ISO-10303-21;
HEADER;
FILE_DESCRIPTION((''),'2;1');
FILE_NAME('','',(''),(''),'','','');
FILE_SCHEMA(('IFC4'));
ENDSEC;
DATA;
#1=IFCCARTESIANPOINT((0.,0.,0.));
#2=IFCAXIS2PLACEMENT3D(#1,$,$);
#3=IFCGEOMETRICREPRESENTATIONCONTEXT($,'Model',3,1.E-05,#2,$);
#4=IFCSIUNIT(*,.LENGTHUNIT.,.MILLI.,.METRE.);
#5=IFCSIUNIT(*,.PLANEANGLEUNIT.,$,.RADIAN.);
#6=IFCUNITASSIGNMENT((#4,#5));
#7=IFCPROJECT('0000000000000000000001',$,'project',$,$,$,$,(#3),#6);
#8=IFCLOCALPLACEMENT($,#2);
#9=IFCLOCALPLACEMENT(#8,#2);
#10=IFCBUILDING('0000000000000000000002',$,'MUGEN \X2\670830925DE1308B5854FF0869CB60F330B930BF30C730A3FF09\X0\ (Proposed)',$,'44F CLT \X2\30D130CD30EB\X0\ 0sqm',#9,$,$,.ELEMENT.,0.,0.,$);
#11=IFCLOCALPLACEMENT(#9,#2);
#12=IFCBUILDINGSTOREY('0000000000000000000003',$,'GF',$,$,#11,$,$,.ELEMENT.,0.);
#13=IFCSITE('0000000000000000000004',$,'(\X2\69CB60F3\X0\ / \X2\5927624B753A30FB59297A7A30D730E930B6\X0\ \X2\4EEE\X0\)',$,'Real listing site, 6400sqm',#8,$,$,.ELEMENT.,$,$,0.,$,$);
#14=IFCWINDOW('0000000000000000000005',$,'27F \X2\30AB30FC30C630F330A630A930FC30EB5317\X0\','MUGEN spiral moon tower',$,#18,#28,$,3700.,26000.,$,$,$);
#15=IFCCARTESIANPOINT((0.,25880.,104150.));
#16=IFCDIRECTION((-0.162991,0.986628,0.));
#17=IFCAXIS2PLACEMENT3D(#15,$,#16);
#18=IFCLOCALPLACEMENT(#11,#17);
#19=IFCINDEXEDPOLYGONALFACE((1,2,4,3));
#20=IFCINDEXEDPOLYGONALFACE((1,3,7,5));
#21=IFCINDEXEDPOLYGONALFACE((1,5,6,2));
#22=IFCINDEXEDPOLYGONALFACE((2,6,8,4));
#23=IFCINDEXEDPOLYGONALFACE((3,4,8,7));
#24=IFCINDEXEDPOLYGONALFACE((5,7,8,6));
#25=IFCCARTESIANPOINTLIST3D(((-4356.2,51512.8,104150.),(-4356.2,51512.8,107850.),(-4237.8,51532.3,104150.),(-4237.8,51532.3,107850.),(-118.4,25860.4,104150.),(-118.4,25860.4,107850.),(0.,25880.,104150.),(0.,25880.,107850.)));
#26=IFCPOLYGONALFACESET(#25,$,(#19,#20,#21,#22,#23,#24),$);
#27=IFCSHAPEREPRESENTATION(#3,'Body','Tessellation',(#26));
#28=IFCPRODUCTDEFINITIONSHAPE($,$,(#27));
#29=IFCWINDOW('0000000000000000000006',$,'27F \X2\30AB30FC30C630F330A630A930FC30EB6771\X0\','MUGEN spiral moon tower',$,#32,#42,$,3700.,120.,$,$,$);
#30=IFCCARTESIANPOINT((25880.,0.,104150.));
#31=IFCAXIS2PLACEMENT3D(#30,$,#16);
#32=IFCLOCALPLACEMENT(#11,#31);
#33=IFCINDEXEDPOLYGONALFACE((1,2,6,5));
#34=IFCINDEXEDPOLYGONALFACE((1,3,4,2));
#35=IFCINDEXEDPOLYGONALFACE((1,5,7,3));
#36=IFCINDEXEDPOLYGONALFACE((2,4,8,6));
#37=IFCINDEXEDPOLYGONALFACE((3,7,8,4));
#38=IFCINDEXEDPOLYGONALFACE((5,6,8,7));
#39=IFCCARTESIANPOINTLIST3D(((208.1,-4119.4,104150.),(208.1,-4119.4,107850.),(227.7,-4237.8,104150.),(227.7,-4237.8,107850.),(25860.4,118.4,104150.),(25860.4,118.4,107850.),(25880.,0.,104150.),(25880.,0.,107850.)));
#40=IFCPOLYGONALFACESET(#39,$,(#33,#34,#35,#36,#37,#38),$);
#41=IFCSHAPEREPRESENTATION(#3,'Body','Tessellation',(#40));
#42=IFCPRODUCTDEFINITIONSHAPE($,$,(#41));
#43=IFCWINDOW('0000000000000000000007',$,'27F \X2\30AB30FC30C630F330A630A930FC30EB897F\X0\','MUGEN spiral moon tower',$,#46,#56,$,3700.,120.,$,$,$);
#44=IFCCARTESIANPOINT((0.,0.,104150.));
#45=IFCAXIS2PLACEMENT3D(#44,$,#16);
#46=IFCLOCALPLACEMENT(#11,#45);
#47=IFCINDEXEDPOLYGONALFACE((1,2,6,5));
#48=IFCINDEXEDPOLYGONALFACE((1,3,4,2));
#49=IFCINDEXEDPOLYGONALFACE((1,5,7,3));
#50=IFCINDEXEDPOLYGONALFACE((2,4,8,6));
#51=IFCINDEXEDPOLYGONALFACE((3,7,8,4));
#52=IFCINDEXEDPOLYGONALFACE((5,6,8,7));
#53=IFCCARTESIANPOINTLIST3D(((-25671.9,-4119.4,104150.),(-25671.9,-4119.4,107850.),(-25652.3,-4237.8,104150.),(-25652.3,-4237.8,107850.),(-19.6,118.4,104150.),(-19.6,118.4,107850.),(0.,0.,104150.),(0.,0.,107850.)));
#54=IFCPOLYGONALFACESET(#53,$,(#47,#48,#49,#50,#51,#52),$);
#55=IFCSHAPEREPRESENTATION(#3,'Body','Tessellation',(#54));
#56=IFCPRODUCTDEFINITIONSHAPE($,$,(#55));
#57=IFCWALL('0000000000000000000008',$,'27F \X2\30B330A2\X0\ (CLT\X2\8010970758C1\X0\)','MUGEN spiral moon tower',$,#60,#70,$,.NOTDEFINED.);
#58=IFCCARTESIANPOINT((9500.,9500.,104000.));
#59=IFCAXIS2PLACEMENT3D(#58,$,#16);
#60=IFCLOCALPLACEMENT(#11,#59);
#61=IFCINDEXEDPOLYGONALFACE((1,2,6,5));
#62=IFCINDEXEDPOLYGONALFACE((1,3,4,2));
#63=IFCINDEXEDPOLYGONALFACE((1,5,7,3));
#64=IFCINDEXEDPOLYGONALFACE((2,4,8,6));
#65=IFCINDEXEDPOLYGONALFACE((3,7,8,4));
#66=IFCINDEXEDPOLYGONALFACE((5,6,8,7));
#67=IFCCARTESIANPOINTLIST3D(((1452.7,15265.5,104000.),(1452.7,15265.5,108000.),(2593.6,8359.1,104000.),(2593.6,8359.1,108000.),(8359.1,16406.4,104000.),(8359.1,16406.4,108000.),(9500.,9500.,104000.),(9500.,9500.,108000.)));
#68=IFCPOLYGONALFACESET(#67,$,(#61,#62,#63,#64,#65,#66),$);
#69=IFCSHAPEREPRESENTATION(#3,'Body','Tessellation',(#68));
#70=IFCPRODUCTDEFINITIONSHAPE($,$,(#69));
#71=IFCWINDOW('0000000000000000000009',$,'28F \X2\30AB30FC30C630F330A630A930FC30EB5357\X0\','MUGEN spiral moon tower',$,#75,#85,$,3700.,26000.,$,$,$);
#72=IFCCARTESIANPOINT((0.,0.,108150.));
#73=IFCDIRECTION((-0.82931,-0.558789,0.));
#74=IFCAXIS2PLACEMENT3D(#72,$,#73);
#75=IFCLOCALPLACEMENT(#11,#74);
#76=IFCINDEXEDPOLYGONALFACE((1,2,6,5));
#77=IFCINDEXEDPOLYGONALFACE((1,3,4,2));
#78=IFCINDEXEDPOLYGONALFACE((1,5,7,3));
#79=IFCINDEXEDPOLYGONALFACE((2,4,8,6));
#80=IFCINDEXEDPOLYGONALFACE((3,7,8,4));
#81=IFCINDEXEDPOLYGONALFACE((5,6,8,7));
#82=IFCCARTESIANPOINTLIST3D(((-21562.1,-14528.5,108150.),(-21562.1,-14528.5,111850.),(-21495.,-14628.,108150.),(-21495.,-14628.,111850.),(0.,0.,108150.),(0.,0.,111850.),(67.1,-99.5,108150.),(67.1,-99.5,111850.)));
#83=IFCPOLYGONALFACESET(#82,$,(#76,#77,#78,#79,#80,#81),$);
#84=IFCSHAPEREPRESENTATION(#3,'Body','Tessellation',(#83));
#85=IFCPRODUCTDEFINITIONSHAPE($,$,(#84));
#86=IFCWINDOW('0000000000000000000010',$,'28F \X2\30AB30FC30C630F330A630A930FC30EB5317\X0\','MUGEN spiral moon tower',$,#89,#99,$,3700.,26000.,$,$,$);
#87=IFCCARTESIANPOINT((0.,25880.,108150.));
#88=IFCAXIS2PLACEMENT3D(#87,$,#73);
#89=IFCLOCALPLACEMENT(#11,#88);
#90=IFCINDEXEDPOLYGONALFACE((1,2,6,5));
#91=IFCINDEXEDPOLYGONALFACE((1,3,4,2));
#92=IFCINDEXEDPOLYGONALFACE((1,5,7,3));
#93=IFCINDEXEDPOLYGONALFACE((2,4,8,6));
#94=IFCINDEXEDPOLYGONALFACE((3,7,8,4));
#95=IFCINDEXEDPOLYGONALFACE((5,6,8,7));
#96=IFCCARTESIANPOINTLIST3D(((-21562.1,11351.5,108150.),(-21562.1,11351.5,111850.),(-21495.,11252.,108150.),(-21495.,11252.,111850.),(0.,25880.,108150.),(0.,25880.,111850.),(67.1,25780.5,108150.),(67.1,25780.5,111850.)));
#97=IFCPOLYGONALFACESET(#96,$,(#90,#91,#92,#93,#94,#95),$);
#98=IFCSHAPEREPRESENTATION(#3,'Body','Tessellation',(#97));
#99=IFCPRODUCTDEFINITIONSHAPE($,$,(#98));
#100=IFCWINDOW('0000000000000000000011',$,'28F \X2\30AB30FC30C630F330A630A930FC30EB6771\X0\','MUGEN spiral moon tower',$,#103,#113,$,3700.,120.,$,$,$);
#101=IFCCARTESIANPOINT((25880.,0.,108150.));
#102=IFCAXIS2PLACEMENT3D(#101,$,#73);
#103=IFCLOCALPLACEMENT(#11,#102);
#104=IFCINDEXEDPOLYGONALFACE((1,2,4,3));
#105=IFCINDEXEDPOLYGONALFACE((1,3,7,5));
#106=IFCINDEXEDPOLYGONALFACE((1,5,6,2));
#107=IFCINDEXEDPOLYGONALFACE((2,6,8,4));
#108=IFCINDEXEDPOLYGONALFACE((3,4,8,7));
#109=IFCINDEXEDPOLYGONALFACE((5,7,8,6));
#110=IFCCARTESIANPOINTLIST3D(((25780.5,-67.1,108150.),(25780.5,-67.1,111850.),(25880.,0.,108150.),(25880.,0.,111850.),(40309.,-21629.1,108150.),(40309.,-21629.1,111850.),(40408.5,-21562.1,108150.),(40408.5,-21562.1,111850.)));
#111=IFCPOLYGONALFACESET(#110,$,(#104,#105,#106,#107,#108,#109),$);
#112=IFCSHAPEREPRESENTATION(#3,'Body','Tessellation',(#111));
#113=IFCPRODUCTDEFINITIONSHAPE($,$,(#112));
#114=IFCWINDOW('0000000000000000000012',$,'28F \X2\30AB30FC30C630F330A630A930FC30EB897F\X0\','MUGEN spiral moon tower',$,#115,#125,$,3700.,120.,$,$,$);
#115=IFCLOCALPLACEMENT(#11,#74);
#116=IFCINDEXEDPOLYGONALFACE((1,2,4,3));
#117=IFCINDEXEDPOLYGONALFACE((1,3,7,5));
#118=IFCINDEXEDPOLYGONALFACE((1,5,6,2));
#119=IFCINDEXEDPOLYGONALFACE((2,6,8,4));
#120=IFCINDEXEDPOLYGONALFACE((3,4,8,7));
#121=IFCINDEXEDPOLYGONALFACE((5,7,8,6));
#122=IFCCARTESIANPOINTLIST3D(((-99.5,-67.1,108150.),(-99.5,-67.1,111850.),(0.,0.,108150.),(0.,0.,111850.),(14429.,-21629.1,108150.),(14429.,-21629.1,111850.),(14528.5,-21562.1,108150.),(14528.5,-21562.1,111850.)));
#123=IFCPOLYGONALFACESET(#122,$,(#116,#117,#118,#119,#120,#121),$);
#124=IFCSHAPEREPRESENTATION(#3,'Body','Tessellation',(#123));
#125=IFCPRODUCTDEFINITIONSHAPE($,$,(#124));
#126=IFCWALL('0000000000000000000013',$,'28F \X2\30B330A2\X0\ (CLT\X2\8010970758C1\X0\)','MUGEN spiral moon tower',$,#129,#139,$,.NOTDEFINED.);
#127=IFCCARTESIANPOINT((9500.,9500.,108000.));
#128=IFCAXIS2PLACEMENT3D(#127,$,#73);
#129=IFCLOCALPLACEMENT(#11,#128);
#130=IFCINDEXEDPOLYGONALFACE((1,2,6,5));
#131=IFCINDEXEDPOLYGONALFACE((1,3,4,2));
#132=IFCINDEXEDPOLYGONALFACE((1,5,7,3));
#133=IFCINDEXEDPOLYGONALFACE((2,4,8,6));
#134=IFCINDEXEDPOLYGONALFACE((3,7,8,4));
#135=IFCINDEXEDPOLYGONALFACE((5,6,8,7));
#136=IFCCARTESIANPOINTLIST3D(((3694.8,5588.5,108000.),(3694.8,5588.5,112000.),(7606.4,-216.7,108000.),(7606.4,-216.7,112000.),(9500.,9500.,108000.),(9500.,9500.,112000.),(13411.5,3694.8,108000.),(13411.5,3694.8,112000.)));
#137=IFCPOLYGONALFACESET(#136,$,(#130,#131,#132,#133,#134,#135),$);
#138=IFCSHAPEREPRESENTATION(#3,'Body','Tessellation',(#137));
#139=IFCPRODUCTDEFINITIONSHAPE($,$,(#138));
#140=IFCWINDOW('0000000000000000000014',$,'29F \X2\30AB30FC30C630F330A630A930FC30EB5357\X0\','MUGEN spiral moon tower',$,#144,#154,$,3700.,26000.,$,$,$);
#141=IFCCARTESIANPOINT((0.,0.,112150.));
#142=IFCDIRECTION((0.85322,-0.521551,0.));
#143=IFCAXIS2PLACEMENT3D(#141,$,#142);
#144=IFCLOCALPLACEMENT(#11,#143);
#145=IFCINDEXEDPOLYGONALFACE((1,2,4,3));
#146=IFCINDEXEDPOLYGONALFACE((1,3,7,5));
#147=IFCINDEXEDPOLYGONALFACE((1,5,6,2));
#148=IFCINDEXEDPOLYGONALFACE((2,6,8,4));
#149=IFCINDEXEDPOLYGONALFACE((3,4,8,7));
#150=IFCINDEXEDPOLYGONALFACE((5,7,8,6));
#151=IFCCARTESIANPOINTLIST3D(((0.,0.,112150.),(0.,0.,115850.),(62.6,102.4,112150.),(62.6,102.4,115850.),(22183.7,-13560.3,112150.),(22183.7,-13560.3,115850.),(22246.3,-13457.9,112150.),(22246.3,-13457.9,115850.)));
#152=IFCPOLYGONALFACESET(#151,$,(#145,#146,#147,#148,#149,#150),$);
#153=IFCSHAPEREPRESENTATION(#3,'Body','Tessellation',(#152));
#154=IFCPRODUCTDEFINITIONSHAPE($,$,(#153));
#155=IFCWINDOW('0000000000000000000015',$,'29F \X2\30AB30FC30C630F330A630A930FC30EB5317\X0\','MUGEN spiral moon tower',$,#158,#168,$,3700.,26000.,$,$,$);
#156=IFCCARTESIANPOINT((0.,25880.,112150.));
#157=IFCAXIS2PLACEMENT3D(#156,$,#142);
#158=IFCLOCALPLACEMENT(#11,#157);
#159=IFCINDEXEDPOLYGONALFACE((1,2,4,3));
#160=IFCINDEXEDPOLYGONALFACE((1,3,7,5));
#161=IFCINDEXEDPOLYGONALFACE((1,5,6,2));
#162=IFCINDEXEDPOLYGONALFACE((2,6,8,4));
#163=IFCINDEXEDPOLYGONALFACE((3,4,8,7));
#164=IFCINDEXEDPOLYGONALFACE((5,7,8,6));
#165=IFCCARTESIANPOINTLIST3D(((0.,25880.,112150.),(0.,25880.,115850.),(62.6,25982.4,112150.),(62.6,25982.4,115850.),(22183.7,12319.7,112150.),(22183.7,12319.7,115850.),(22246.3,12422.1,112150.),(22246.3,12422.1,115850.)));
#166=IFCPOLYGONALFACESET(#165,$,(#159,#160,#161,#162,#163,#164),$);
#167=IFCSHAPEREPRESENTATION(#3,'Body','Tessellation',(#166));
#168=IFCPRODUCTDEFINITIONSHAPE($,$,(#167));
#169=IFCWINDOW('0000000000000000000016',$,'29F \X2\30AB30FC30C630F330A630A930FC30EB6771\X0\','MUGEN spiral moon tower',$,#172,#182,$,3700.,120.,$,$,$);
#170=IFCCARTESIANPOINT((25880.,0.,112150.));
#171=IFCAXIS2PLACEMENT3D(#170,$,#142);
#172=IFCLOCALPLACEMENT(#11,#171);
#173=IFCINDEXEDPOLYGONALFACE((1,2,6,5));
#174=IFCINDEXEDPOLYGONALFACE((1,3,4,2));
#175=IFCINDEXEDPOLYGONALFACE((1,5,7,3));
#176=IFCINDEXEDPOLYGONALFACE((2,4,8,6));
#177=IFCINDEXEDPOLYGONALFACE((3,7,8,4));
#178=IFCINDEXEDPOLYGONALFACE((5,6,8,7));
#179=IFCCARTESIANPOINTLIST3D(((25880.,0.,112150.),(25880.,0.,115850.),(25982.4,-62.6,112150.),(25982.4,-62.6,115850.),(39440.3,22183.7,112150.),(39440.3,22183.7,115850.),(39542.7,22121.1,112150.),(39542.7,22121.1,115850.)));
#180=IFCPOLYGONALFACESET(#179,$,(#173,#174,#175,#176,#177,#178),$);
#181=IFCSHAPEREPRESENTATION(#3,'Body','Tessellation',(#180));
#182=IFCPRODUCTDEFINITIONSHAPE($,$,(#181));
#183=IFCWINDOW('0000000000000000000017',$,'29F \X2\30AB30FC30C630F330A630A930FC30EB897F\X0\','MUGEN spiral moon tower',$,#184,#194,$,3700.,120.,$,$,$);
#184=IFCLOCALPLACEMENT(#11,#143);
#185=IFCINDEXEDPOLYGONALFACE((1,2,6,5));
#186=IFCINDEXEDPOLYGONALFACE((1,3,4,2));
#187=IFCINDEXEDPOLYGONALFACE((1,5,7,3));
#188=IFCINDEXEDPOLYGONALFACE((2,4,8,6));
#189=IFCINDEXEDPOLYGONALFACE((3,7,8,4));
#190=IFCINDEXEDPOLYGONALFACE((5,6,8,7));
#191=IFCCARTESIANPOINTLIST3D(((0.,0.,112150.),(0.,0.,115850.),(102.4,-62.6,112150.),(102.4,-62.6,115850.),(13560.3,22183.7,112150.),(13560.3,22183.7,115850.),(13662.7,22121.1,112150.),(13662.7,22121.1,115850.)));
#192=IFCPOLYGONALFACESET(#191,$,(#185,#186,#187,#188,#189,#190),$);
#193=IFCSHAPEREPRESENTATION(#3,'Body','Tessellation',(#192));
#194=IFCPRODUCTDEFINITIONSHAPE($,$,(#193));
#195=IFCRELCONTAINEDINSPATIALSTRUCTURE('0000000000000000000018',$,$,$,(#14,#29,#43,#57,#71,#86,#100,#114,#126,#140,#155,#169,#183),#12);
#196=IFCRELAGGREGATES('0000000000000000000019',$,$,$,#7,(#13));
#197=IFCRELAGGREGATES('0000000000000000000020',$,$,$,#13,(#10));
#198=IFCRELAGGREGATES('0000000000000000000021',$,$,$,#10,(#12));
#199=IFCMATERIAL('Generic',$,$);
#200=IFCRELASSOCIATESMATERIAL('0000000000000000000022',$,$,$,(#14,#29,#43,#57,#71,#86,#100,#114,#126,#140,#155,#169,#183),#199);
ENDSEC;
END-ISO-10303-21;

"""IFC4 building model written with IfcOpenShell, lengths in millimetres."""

from ifc_helpers import new_model, si_unit, frame, frame_2d, origin, place, context, project, spatial, rectangle, extrude, material, element, save


model = new_model("IFC4")

# Units and contexts
model_context = context("Model", 3, precision=1e-05, world=origin())
ifc_project = project(units=[si_unit("LENGTHUNIT", "METRE", prefix="MILLI"), si_unit("PLANEANGLEUNIT", "RADIAN")], contexts=[model_context])

# Site, building, storey
site_placement = place(None, origin())
site = spatial("IfcSite", under=ifc_project, at=site_placement, Name="(構想 / 大手町・天空プラザ 仮)", ObjectType="Real listing site, 6400sqm", CompositionType="ELEMENT", RefElevation=0.0)
building_placement = place(site_placement, origin())
building = spatial("IfcBuilding", under=site, at=building_placement, Name="MUGEN 月を巡る塔（構想スタディ） (Proposed)", ObjectType="44F CLT パネル 0sqm", CompositionType="ELEMENT", ElevationOfRefHeight=0.0, ElevationOfTerrain=0.0)
storey_placement = place(building_placement, origin())
storey = spatial("IfcBuildingStorey", under=building, at=storey_placement, Name="GF", CompositionType="ELEMENT", Elevation=0.0)

# Shared definitions
ifc_material = material(Name="Generic")

# Windows
window_1_placement = place(storey_placement, frame((0.0, 25880.0, 104150.0), x_axis=(-0.162991, 0.986628, 0.0)))
element("IfcWindow", 1, at=window_1_placement, inside=storey, material=ifc_material, Name="27F カーテンウォール北", Description="MUGEN spiral moon tower", OverallHeight=3700.0, OverallWidth=26000.0, context=model_context, shape_type="SweptSolid", body=[
    extrude(rectangle(XDim=26000.0, YDim=120.0, at=frame_2d((13000.0, 60.0))), frame((0.0, 25880.0, 104150.0), x_axis=(-0.162991, 0.986628, 0.0)), (0.0, 0.0, 1.0), 3700.0),
])
window_2_placement = place(storey_placement, frame((25880.0, 0.0, 104150.0), x_axis=(-0.162991, 0.986628, 0.0)))
element("IfcWindow", 2, at=window_2_placement, inside=storey, material=ifc_material, Name="27F カーテンウォール東", Description="MUGEN spiral moon tower", OverallHeight=3700.0, OverallWidth=120.0, context=model_context, shape_type="SweptSolid", body=[
    extrude(rectangle(XDim=120.0, YDim=26000.0, at=frame_2d((60.0, 13000.0))), frame((25880.0, 0.0, 104150.0), x_axis=(-0.162991, 0.986628, 0.0)), (0.0, 0.0, 1.0), 3700.0),
])
window_3_placement = place(storey_placement, frame((0.0, 0.0, 104150.0), x_axis=(-0.162991, 0.986628, 0.0)))
element("IfcWindow", 3, at=window_3_placement, inside=storey, material=ifc_material, Name="27F カーテンウォール西", Description="MUGEN spiral moon tower", OverallHeight=3700.0, OverallWidth=120.0, context=model_context, shape_type="SweptSolid", body=[
    extrude(rectangle(XDim=120.0, YDim=26000.0, at=frame_2d((60.0, 13000.0))), frame((0.0, 0.0, 104150.0), x_axis=(-0.162991, 0.986628, 0.0)), (0.0, 0.0, 1.0), 3700.0),
])

# Wall
wall_1_placement = place(storey_placement, frame((9500.0, 9500.0, 104000.0), x_axis=(-0.162991, 0.986628, 0.0)))
element("IfcWall", 4, at=wall_1_placement, inside=storey, material=ifc_material, Name="27F コア (CLT耐震壁)", Description="MUGEN spiral moon tower", PredefinedType="NOTDEFINED", context=model_context, shape_type="SweptSolid", body=[
    extrude(rectangle(XDim=7000.0, YDim=7000.0, at=frame_2d((3500.0, 3500.0))), frame((9500.0, 9500.0, 104000.0), x_axis=(-0.162991, 0.986628, 0.0)), (0.0, 0.0, 1.0), 4000.0),
])

# Windows
window_4_placement = place(storey_placement, frame((0.0, 0.0, 108150.0), x_axis=(-0.82931, -0.558789, 0.0)))
element("IfcWindow", 5, at=window_4_placement, inside=storey, material=ifc_material, Name="28F カーテンウォール南", Description="MUGEN spiral moon tower", OverallHeight=3700.0, OverallWidth=26000.0, context=model_context, shape_type="SweptSolid", body=[
    extrude(rectangle(XDim=26000.0, YDim=120.0, at=frame_2d((13000.0, 60.0))), frame((0.0, 0.0, 108150.0), x_axis=(-0.82931, -0.558789, 0.0)), (0.0, 0.0, 1.0), 3700.0),
])
window_5_placement = place(storey_placement, frame((0.0, 25880.0, 108150.0), x_axis=(-0.82931, -0.558789, 0.0)))
element("IfcWindow", 6, at=window_5_placement, inside=storey, material=ifc_material, Name="28F カーテンウォール北", Description="MUGEN spiral moon tower", OverallHeight=3700.0, OverallWidth=26000.0, context=model_context, shape_type="SweptSolid", body=[
    extrude(rectangle(XDim=26000.0, YDim=120.0, at=frame_2d((13000.0, 60.0))), frame((0.0, 25880.0, 108150.0), x_axis=(-0.82931, -0.558789, 0.0)), (0.0, 0.0, 1.0), 3700.0),
])
window_6_placement = place(storey_placement, frame((25880.0, 0.0, 108150.0), x_axis=(-0.82931, -0.558789, 0.0)))
element("IfcWindow", 7, at=window_6_placement, inside=storey, material=ifc_material, Name="28F カーテンウォール東", Description="MUGEN spiral moon tower", OverallHeight=3700.0, OverallWidth=120.0, context=model_context, shape_type="SweptSolid", body=[
    extrude(rectangle(XDim=120.0, YDim=26000.0, at=frame_2d((60.0, 13000.0))), frame((25880.0, 0.0, 108150.0), x_axis=(-0.82931, -0.558789, 0.0)), (0.0, 0.0, 1.0), 3700.0),
])
window_7_placement = place(storey_placement, frame((0.0, 0.0, 108150.0), x_axis=(-0.82931, -0.558789, 0.0)))
element("IfcWindow", 8, at=window_7_placement, inside=storey, material=ifc_material, Name="28F カーテンウォール西", Description="MUGEN spiral moon tower", OverallHeight=3700.0, OverallWidth=120.0, context=model_context, shape_type="SweptSolid", body=[
    extrude(rectangle(XDim=120.0, YDim=26000.0, at=frame_2d((60.0, 13000.0))), frame((0.0, 0.0, 108150.0), x_axis=(-0.82931, -0.558789, 0.0)), (0.0, 0.0, 1.0), 3700.0),
])

# Wall
wall_2_placement = place(storey_placement, frame((9500.0, 9500.0, 108000.0), x_axis=(-0.82931, -0.558789, 0.0)))
element("IfcWall", 9, at=wall_2_placement, inside=storey, material=ifc_material, Name="28F コア (CLT耐震壁)", Description="MUGEN spiral moon tower", PredefinedType="NOTDEFINED", context=model_context, shape_type="SweptSolid", body=[
    extrude(rectangle(XDim=7000.0, YDim=7000.0, at=frame_2d((3500.0, 3500.0))), frame((9500.0, 9500.0, 108000.0), x_axis=(-0.82931, -0.558789, 0.0)), (0.0, 0.0, 1.0), 4000.0),
])

# Windows
window_8_placement = place(storey_placement, frame((0.0, 0.0, 112150.0), x_axis=(0.85322, -0.521551, 0.0)))
element("IfcWindow", 10, at=window_8_placement, inside=storey, material=ifc_material, Name="29F カーテンウォール南", Description="MUGEN spiral moon tower", OverallHeight=3700.0, OverallWidth=26000.0, context=model_context, shape_type="SweptSolid", body=[
    extrude(rectangle(XDim=26000.0, YDim=120.0, at=frame_2d((13000.0, 60.0))), frame((0.0, 0.0, 112150.0), x_axis=(0.85322, -0.521551, 0.0)), (0.0, 0.0, 1.0), 3700.0),
])
window_9_placement = place(storey_placement, frame((0.0, 25880.0, 112150.0), x_axis=(0.85322, -0.521551, 0.0)))
element("IfcWindow", 11, at=window_9_placement, inside=storey, material=ifc_material, Name="29F カーテンウォール北", Description="MUGEN spiral moon tower", OverallHeight=3700.0, OverallWidth=26000.0, context=model_context, shape_type="SweptSolid", body=[
    extrude(rectangle(XDim=26000.0, YDim=120.0, at=frame_2d((13000.0, 60.0))), frame((0.0, 25880.0, 112150.0), x_axis=(0.85322, -0.521551, 0.0)), (0.0, 0.0, 1.0), 3700.0),
])
window_10_placement = place(storey_placement, frame((25880.0, 0.0, 112150.0), x_axis=(0.85322, -0.521551, 0.0)))
element("IfcWindow", 12, at=window_10_placement, inside=storey, material=ifc_material, Name="29F カーテンウォール東", Description="MUGEN spiral moon tower", OverallHeight=3700.0, OverallWidth=120.0, context=model_context, shape_type="SweptSolid", body=[
    extrude(rectangle(XDim=120.0, YDim=26000.0, at=frame_2d((60.0, 13000.0))), frame((25880.0, 0.0, 112150.0), x_axis=(0.85322, -0.521551, 0.0)), (0.0, 0.0, 1.0), 3700.0),
])
window_11_placement = place(storey_placement, frame((0.0, 0.0, 112150.0), x_axis=(0.85322, -0.521551, 0.0)))
element("IfcWindow", 13, at=window_11_placement, inside=storey, material=ifc_material, Name="29F カーテンウォール西", Description="MUGEN spiral moon tower", OverallHeight=3700.0, OverallWidth=120.0, context=model_context, shape_type="SweptSolid", body=[
    extrude(rectangle(XDim=120.0, YDim=26000.0, at=frame_2d((60.0, 13000.0))), frame((0.0, 0.0, 112150.0), x_axis=(0.85322, -0.521551, 0.0)), (0.0, 0.0, 1.0), 3700.0),
])

save(model, "model.ifc")
